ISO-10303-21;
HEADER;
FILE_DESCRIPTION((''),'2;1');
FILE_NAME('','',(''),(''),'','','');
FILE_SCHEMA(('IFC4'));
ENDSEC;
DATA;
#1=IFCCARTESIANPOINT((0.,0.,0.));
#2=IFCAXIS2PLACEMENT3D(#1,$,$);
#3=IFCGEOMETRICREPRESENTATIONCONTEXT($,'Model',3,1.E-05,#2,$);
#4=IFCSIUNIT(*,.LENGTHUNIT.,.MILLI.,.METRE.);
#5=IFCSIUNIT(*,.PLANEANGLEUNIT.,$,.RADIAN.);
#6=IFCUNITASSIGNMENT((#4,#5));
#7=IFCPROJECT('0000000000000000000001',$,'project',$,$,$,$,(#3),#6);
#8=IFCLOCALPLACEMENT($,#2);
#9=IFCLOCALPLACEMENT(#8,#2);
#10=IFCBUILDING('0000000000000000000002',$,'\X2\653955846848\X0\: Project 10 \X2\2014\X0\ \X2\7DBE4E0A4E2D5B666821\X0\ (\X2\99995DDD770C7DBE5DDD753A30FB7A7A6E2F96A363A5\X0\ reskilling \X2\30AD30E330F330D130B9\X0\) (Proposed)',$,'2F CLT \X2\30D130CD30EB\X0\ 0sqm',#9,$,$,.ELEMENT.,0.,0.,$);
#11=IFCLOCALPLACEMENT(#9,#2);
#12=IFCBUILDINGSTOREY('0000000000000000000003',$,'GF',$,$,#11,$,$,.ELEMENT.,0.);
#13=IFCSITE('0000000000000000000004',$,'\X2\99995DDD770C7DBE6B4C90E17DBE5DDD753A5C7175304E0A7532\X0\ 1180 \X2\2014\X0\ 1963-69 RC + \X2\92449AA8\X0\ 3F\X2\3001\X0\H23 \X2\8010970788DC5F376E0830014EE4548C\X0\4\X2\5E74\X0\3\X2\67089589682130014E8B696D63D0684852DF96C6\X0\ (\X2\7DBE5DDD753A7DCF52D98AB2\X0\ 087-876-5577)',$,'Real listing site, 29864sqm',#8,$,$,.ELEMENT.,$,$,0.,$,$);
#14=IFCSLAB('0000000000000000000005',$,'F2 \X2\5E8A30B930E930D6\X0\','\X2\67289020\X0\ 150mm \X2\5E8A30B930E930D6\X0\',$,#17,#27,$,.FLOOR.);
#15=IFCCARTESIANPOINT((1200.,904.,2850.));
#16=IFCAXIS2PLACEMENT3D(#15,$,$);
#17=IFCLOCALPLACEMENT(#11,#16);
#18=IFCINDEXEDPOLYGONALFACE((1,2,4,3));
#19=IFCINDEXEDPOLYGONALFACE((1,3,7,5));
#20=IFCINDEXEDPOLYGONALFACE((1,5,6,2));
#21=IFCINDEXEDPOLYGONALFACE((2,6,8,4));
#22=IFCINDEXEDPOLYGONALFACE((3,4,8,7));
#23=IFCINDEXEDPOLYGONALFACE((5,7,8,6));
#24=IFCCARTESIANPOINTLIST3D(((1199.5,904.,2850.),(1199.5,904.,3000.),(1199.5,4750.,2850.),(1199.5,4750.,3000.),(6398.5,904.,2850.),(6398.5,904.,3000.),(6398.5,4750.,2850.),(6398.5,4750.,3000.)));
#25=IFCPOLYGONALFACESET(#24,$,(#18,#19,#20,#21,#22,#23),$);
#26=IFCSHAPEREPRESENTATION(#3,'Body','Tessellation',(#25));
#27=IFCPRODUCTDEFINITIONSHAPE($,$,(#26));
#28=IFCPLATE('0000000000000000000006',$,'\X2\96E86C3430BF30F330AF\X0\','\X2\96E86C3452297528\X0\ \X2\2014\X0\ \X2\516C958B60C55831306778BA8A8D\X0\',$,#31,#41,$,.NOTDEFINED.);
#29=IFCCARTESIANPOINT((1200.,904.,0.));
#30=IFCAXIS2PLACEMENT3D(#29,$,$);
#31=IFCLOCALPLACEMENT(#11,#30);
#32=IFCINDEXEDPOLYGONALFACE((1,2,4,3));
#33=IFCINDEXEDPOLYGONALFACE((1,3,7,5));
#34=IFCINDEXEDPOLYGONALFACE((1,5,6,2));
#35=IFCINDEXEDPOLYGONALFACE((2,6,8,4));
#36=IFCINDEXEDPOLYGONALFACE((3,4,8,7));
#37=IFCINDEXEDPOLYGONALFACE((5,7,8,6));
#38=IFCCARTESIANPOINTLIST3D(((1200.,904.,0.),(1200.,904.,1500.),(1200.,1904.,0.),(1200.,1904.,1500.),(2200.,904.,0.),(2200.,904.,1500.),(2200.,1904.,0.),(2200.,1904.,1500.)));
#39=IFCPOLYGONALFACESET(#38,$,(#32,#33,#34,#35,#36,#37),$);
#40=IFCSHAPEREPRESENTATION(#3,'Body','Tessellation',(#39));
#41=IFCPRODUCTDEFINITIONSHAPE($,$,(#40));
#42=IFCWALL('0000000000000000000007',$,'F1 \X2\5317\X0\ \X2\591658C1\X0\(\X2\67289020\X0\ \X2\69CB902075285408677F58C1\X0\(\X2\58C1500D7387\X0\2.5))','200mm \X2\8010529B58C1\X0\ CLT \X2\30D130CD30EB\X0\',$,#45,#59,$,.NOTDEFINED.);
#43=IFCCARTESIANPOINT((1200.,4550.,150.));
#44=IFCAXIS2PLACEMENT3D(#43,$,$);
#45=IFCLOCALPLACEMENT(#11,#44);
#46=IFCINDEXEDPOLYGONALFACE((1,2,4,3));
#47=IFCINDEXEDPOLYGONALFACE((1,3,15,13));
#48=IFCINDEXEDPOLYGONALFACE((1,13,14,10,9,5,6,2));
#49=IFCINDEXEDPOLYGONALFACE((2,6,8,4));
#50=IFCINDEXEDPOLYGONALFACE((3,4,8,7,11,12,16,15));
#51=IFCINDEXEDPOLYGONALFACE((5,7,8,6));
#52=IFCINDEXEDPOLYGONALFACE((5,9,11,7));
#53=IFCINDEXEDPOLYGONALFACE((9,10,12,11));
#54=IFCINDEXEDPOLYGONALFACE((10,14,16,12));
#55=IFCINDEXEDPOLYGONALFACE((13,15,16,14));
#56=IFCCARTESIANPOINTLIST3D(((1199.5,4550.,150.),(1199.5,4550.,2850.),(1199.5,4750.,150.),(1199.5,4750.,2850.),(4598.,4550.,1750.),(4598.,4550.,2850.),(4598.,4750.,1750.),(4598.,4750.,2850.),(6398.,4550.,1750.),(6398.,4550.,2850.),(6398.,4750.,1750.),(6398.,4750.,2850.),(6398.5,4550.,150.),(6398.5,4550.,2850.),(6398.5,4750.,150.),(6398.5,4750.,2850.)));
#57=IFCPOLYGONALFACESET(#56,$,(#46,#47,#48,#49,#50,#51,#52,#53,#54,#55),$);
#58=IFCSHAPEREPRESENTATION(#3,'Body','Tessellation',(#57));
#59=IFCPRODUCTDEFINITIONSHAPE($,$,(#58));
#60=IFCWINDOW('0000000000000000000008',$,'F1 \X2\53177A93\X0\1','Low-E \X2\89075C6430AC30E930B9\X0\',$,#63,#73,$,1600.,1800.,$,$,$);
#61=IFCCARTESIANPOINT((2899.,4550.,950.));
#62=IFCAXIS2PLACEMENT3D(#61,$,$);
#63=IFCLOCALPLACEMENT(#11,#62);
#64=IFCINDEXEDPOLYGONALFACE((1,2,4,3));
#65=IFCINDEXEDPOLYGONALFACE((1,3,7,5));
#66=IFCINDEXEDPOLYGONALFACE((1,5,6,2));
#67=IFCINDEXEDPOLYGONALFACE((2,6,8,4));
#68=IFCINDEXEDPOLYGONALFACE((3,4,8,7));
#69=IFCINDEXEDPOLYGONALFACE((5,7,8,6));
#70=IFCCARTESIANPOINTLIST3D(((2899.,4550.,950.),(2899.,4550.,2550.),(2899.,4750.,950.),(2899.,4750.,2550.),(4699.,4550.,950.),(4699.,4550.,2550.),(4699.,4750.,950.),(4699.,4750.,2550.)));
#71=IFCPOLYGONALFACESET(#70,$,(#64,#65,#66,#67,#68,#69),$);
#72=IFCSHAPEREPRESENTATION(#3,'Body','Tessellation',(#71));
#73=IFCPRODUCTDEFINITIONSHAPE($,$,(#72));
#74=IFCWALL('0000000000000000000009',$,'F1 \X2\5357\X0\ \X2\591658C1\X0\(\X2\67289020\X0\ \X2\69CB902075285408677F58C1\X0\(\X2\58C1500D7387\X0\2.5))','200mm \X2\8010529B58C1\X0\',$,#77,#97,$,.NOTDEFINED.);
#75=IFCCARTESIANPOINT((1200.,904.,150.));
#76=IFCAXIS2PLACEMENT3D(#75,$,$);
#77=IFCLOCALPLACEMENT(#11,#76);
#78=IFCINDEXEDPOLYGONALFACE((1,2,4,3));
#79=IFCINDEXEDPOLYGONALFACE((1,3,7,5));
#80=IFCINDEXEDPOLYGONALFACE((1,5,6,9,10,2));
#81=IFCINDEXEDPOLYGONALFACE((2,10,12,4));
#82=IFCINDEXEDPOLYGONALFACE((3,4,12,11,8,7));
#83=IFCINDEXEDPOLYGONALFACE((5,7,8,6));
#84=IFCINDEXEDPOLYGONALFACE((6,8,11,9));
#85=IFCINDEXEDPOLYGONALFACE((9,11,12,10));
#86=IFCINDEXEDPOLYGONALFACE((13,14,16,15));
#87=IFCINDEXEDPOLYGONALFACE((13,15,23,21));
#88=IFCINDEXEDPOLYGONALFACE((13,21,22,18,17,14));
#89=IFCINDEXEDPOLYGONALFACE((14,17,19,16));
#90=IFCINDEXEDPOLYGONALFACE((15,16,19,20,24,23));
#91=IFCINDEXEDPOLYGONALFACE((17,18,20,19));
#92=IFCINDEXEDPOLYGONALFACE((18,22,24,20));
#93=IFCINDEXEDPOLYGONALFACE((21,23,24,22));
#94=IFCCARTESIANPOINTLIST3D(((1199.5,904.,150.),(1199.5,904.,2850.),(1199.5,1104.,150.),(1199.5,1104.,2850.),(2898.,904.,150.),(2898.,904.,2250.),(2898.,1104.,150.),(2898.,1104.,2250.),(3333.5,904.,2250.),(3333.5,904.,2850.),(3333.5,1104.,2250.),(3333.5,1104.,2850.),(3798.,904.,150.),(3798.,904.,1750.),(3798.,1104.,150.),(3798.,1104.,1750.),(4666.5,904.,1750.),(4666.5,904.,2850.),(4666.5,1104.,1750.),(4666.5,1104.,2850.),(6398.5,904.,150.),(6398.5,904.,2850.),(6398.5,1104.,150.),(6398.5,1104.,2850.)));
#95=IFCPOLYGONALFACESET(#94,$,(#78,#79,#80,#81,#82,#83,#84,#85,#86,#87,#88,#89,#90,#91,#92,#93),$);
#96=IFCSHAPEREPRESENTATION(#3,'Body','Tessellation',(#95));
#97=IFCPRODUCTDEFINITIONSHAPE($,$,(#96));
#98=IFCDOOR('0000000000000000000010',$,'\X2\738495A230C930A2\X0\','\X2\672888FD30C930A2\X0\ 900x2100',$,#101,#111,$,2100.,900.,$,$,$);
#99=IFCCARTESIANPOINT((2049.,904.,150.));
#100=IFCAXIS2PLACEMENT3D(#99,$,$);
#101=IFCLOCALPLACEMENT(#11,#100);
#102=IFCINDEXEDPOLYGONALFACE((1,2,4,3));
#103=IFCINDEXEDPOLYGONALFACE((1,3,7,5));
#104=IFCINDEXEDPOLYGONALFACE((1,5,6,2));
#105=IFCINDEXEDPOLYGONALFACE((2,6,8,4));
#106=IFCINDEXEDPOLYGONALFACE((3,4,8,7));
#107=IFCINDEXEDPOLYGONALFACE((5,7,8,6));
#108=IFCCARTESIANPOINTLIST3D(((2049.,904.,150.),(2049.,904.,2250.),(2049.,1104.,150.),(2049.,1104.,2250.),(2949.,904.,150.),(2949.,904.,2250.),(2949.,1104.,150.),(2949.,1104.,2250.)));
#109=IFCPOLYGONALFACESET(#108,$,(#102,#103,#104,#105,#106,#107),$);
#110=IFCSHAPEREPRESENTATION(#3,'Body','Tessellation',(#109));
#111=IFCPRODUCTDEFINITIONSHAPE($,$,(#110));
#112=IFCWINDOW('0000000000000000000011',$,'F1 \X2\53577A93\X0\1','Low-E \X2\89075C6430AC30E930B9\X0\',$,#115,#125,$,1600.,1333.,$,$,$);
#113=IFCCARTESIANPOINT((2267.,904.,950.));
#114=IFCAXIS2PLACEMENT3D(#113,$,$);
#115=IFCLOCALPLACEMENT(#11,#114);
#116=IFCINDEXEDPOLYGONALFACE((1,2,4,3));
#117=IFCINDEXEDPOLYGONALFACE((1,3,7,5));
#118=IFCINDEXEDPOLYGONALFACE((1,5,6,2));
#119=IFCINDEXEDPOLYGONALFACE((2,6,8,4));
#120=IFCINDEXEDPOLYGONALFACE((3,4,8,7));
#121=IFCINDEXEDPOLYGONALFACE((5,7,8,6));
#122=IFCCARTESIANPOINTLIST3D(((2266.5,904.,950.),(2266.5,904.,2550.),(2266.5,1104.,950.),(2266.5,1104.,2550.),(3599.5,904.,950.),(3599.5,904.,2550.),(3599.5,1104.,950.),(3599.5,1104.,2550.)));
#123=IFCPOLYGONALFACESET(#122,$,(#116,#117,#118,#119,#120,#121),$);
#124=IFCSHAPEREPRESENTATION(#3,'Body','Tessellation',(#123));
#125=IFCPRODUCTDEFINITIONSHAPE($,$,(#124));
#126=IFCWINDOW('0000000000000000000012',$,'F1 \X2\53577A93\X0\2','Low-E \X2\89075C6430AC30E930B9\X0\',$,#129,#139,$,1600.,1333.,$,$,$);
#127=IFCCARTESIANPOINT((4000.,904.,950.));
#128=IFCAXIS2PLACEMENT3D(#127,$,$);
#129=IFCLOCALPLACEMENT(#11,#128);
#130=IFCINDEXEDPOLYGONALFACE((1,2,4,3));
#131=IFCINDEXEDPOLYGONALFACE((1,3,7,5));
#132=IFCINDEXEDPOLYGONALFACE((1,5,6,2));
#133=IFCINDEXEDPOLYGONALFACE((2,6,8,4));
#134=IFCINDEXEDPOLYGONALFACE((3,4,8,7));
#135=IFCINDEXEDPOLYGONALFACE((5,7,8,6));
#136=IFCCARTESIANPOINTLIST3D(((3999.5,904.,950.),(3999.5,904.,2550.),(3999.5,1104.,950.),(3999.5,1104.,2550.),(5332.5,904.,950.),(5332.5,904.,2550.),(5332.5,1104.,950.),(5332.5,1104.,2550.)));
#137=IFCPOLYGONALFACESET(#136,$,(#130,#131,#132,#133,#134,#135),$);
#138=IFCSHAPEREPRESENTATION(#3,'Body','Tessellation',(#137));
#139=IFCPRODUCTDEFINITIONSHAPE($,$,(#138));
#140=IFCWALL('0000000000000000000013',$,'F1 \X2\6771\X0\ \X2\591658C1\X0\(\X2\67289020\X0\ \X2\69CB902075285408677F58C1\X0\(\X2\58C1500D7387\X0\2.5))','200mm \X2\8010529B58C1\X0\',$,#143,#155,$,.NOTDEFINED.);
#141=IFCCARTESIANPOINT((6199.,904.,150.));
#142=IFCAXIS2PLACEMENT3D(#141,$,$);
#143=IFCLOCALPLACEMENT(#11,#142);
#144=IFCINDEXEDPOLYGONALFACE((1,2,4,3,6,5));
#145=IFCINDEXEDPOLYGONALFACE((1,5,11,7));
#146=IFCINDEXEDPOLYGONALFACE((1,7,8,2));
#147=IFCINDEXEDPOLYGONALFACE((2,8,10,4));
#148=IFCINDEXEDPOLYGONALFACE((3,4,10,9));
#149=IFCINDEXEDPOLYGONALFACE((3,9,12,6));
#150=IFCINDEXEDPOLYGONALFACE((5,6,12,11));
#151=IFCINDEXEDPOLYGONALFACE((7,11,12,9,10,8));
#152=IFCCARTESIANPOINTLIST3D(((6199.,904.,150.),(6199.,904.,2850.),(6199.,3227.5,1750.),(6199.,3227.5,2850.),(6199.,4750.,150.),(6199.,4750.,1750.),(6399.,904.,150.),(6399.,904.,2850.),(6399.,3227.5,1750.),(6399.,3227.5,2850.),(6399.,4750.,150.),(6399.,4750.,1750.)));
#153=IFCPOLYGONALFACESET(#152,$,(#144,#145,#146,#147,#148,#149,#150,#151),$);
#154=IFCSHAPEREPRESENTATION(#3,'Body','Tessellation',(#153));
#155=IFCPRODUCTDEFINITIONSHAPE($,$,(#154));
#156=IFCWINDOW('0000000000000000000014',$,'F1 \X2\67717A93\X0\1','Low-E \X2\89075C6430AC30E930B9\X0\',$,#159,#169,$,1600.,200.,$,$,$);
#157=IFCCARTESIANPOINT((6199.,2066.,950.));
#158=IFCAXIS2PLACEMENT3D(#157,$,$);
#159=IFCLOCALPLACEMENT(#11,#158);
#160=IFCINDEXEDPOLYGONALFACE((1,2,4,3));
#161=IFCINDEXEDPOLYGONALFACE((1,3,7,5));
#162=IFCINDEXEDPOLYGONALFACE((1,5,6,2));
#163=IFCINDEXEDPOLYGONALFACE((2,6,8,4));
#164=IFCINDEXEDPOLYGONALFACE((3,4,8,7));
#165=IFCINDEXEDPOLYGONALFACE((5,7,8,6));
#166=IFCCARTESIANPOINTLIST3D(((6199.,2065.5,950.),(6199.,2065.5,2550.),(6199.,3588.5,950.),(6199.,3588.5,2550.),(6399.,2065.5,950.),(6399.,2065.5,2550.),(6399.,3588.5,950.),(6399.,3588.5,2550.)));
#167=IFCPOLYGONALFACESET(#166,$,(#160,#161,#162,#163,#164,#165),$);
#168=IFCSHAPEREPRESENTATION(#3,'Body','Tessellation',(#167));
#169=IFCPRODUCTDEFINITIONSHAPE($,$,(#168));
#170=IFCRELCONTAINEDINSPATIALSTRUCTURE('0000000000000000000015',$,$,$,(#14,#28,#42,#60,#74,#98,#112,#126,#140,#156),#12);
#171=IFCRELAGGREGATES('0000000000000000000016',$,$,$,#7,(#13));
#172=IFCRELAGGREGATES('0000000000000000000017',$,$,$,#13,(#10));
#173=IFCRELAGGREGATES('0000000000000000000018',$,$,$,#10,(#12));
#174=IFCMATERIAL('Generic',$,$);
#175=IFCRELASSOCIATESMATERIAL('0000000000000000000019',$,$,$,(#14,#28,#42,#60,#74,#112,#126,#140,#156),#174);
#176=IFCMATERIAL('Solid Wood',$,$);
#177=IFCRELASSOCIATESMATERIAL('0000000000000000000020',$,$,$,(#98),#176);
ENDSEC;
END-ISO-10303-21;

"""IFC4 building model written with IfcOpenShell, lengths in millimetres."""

from ifc_helpers import new_model, si_unit, frame, frame_2d, origin, place, context, project, spatial, rectangle, extrude, material, element, fill, save


model = new_model("IFC4")

# Units and contexts
model_context = context("Model", 3, precision=1e-05, world=origin())
ifc_project = project(units=[si_unit("LENGTHUNIT", "METRE", prefix="MILLI"), si_unit("PLANEANGLEUNIT", "RADIAN")], contexts=[model_context])

# Site, building, storey
site_placement = place(None, origin())
site = spatial("IfcSite", under=ifc_project, at=site_placement, Name="香川県綾歌郡綾川町山田上甲 1180 — 1963-69 RC + 鉄骨 3F、H23 耐震補強済、令和4年3月閉校、事業提案募集 (綾川町総務課 087-876-5577)", ObjectType="Real listing site, 29864sqm", CompositionType="ELEMENT", RefElevation=0.0)
building_placement = place(site_placement, origin())
building = spatial("IfcBuilding", under=site, at=building_placement, Name="改善案: Project 10 — 綾上中学校 (香川県綾川町・空港隣接 reskilling キャンパス) (Proposed)", ObjectType="2F CLT パネル 0sqm", CompositionType="ELEMENT", ElevationOfRefHeight=0.0, ElevationOfTerrain=0.0)
storey_placement = place(building_placement, origin())
storey = spatial("IfcBuildingStorey", under=building, at=storey_placement, Name="GF", CompositionType="ELEMENT", Elevation=0.0)

# Slab
ifc_material_1 = material(Name="Generic")
slab_1_placement = place(storey_placement, frame((1200.0, 904.0, 2850.0)))
element("IfcSlab", 1, at=slab_1_placement, inside=storey, material=ifc_material_1, Name="F2 床スラブ", Description="木造 150mm 床スラブ", PredefinedType="FLOOR", context=model_context, shape_type="SweptSolid", body=[
    extrude(rectangle(XDim=5199.0, YDim=3846.0, at=frame_2d((2599.0, 1923.0))), frame((1200.0, 904.0, 2850.0)), (0.0, 0.0, 1.0), 150.0),
])

# Plate
plate_placement = place(storey_placement, frame((1200.0, 904.0, 0.0)))
element("IfcPlate", 2, at=plate_placement, inside=storey, material=ifc_material_1, Name="雨水タンク", Description="雨水利用 — 公開情報で確認", PredefinedType="NOTDEFINED", context=model_context, shape_type="SweptSolid", body=[
    extrude(rectangle(XDim=1000.0, YDim=1000.0, at=frame_2d((500.0, 500.0))), frame((1200.0, 904.0, 0.0)), (0.0, 0.0, 1.0), 1500.0),
])

# Wall, opening, window
wall_1_placement = place(storey_placement, frame((1200.0, 4550.0, 150.0)))
wall_1 = element("IfcWall", 3, at=wall_1_placement, inside=storey, material=ifc_material_1, Name="F1 北 外壁(木造 構造用合板壁(壁倍率2.5))", Description="200mm 耐力壁 CLT パネル", PredefinedType="NOTDEFINED", context=model_context, shape_type="SweptSolid", body=[
    extrude(rectangle(XDim=5199.0, YDim=200.0, at=frame_2d((2599.0, 100.0))), frame((1200.0, 4550.0, 150.0)), (0.0, 0.0, 1.0), 2700.0),
])
opening_1_placement = place(storey_placement, frame((2899.0, 4550.0, 950.0)))
opening_1 = element("IfcOpeningElement", 4, at=opening_1_placement, cuts=wall_1, PredefinedType="NOTDEFINED", context=model_context, shape_type="SweptSolid", body=[
    extrude(rectangle(XDim=1800.0, YDim=200.0, at=frame_2d((900.0, 100.0))), frame((2899.0, 4550.0, 950.0)), (0.0, 0.0, 1.0), 1600.0),
])
window_1_placement = place(storey_placement, frame((2899.0, 4550.0, 950.0)))
window_1 = element("IfcWindow", 5, at=window_1_placement, inside=storey, material=ifc_material_1, Name="F1 北窓1", Description="Low-E 複層ガラス", OverallHeight=1600.0, OverallWidth=1800.0, context=model_context, shape_type="SweptSolid", body=[
    extrude(rectangle(XDim=1800.0, YDim=200.0, at=frame_2d((900.0, 100.0))), frame((2899.0, 4550.0, 950.0)), (0.0, 0.0, 1.0), 1600.0),
])
fill(opening_1, window_1)

# Wall, openings, door, windows
wall_2_placement = place(storey_placement, frame((1200.0, 904.0, 150.0)))
wall_2 = element("IfcWall", 6, at=wall_2_placement, inside=storey, material=ifc_material_1, Name="F1 南 外壁(木造 構造用合板壁(壁倍率2.5))", Description="200mm 耐力壁", PredefinedType="NOTDEFINED", context=model_context, shape_type="SweptSolid", body=[
    extrude(rectangle(XDim=5199.0, YDim=200.0, at=frame_2d((2599.0, 100.0))), frame((1200.0, 904.0, 150.0)), (0.0, 0.0, 1.0), 2700.0),
])
opening_2_placement = place(storey_placement, frame((2049.0, 904.0, 150.0)))
opening_2 = element("IfcOpeningElement", 7, at=opening_2_placement, cuts=wall_2, PredefinedType="NOTDEFINED", context=model_context, shape_type="SweptSolid", body=[
    extrude(rectangle(XDim=900.0, YDim=200.0, at=frame_2d((450.0, 100.0))), frame((2049.0, 904.0, 150.0)), (0.0, 0.0, 1.0), 2100.0),
])
opening_3_placement = place(storey_placement, frame((2267.0, 904.0, 950.0)))
opening_3 = element("IfcOpeningElement", 8, at=opening_3_placement, cuts=wall_2, PredefinedType="NOTDEFINED", context=model_context, shape_type="SweptSolid", body=[
    extrude(rectangle(XDim=1333.0, YDim=200.0, at=frame_2d((666.0, 100.0))), frame((2267.0, 904.0, 950.0)), (0.0, 0.0, 1.0), 1600.0),
])
opening_4_placement = place(storey_placement, frame((4000.0, 904.0, 950.0)))
opening_4 = element("IfcOpeningElement", 9, at=opening_4_placement, cuts=wall_2, PredefinedType="NOTDEFINED", context=model_context, shape_type="SweptSolid", body=[
    extrude(rectangle(XDim=1333.0, YDim=200.0, at=frame_2d((666.0, 100.0))), frame((4000.0, 904.0, 950.0)), (0.0, 0.0, 1.0), 1600.0),
])
ifc_material_2 = material(Name="Solid Wood")
door_placement = place(storey_placement, frame((2049.0, 904.0, 150.0)))
door = element("IfcDoor", 10, at=door_placement, inside=storey, material=ifc_material_2, Name="玄関ドア", Description="木製ドア 900x2100", OverallHeight=2100.0, OverallWidth=900.0, context=model_context, shape_type="SweptSolid", body=[
    extrude(rectangle(XDim=900.0, YDim=200.0, at=frame_2d((450.0, 100.0))), frame((2049.0, 904.0, 150.0)), (0.0, 0.0, 1.0), 2100.0),
])
fill(opening_2, door)
window_2_placement = place(storey_placement, frame((2267.0, 904.0, 950.0)))
window_2 = element("IfcWindow", 11, at=window_2_placement, inside=storey, material=ifc_material_1, Name="F1 南窓1", Description="Low-E 複層ガラス", OverallHeight=1600.0, OverallWidth=1333.0, context=model_context, shape_type="SweptSolid", body=[
    extrude(rectangle(XDim=1333.0, YDim=200.0, at=frame_2d((666.0, 100.0))), frame((2267.0, 904.0, 950.0)), (0.0, 0.0, 1.0), 1600.0),
])
fill(opening_3, window_2)
window_3_placement = place(storey_placement, frame((4000.0, 904.0, 950.0)))
window_3 = element("IfcWindow", 12, at=window_3_placement, inside=storey, material=ifc_material_1, Name="F1 南窓2", Description="Low-E 複層ガラス", OverallHeight=1600.0, OverallWidth=1333.0, context=model_context, shape_type="SweptSolid", body=[
    extrude(rectangle(XDim=1333.0, YDim=200.0, at=frame_2d((666.0, 100.0))), frame((4000.0, 904.0, 950.0)), (0.0, 0.0, 1.0), 1600.0),
])
fill(opening_4, window_3)

# Wall, opening, window
wall_3_placement = place(storey_placement, frame((6199.0, 904.0, 150.0)))
wall_3 = element("IfcWall", 13, at=wall_3_placement, inside=storey, material=ifc_material_1, Name="F1 東 外壁(木造 構造用合板壁(壁倍率2.5))", Description="200mm 耐力壁", PredefinedType="NOTDEFINED", context=model_context, shape_type="SweptSolid", body=[
    extrude(rectangle(XDim=200.0, YDim=3846.0, at=frame_2d((100.0, 1923.0))), frame((6199.0, 904.0, 150.0)), (0.0, 0.0, 1.0), 2700.0),
])
opening_5_placement = place(storey_placement, frame((6199.0, 2066.0, 950.0)))
opening_5 = element("IfcOpeningElement", 14, at=opening_5_placement, cuts=wall_3, PredefinedType="NOTDEFINED", context=model_context, shape_type="SweptSolid", body=[
    extrude(rectangle(XDim=200.0, YDim=1523.0, at=frame_2d((100.0, 761.0))), frame((6199.0, 2066.0, 950.0)), (0.0, 0.0, 1.0), 1600.0),
])
window_4_placement = place(storey_placement, frame((6199.0, 2066.0, 950.0)))
window_4 = element("IfcWindow", 15, at=window_4_placement, inside=storey, material=ifc_material_1, Name="F1 東窓1", Description="Low-E 複層ガラス", OverallHeight=1600.0, OverallWidth=200.0, context=model_context, shape_type="SweptSolid", body=[
    extrude(rectangle(XDim=200.0, YDim=1523.0, at=frame_2d((100.0, 761.0))), frame((6199.0, 2066.0, 950.0)), (0.0, 0.0, 1.0), 1600.0),
])
fill(opening_5, window_4)

save(model, "model.ifc")
